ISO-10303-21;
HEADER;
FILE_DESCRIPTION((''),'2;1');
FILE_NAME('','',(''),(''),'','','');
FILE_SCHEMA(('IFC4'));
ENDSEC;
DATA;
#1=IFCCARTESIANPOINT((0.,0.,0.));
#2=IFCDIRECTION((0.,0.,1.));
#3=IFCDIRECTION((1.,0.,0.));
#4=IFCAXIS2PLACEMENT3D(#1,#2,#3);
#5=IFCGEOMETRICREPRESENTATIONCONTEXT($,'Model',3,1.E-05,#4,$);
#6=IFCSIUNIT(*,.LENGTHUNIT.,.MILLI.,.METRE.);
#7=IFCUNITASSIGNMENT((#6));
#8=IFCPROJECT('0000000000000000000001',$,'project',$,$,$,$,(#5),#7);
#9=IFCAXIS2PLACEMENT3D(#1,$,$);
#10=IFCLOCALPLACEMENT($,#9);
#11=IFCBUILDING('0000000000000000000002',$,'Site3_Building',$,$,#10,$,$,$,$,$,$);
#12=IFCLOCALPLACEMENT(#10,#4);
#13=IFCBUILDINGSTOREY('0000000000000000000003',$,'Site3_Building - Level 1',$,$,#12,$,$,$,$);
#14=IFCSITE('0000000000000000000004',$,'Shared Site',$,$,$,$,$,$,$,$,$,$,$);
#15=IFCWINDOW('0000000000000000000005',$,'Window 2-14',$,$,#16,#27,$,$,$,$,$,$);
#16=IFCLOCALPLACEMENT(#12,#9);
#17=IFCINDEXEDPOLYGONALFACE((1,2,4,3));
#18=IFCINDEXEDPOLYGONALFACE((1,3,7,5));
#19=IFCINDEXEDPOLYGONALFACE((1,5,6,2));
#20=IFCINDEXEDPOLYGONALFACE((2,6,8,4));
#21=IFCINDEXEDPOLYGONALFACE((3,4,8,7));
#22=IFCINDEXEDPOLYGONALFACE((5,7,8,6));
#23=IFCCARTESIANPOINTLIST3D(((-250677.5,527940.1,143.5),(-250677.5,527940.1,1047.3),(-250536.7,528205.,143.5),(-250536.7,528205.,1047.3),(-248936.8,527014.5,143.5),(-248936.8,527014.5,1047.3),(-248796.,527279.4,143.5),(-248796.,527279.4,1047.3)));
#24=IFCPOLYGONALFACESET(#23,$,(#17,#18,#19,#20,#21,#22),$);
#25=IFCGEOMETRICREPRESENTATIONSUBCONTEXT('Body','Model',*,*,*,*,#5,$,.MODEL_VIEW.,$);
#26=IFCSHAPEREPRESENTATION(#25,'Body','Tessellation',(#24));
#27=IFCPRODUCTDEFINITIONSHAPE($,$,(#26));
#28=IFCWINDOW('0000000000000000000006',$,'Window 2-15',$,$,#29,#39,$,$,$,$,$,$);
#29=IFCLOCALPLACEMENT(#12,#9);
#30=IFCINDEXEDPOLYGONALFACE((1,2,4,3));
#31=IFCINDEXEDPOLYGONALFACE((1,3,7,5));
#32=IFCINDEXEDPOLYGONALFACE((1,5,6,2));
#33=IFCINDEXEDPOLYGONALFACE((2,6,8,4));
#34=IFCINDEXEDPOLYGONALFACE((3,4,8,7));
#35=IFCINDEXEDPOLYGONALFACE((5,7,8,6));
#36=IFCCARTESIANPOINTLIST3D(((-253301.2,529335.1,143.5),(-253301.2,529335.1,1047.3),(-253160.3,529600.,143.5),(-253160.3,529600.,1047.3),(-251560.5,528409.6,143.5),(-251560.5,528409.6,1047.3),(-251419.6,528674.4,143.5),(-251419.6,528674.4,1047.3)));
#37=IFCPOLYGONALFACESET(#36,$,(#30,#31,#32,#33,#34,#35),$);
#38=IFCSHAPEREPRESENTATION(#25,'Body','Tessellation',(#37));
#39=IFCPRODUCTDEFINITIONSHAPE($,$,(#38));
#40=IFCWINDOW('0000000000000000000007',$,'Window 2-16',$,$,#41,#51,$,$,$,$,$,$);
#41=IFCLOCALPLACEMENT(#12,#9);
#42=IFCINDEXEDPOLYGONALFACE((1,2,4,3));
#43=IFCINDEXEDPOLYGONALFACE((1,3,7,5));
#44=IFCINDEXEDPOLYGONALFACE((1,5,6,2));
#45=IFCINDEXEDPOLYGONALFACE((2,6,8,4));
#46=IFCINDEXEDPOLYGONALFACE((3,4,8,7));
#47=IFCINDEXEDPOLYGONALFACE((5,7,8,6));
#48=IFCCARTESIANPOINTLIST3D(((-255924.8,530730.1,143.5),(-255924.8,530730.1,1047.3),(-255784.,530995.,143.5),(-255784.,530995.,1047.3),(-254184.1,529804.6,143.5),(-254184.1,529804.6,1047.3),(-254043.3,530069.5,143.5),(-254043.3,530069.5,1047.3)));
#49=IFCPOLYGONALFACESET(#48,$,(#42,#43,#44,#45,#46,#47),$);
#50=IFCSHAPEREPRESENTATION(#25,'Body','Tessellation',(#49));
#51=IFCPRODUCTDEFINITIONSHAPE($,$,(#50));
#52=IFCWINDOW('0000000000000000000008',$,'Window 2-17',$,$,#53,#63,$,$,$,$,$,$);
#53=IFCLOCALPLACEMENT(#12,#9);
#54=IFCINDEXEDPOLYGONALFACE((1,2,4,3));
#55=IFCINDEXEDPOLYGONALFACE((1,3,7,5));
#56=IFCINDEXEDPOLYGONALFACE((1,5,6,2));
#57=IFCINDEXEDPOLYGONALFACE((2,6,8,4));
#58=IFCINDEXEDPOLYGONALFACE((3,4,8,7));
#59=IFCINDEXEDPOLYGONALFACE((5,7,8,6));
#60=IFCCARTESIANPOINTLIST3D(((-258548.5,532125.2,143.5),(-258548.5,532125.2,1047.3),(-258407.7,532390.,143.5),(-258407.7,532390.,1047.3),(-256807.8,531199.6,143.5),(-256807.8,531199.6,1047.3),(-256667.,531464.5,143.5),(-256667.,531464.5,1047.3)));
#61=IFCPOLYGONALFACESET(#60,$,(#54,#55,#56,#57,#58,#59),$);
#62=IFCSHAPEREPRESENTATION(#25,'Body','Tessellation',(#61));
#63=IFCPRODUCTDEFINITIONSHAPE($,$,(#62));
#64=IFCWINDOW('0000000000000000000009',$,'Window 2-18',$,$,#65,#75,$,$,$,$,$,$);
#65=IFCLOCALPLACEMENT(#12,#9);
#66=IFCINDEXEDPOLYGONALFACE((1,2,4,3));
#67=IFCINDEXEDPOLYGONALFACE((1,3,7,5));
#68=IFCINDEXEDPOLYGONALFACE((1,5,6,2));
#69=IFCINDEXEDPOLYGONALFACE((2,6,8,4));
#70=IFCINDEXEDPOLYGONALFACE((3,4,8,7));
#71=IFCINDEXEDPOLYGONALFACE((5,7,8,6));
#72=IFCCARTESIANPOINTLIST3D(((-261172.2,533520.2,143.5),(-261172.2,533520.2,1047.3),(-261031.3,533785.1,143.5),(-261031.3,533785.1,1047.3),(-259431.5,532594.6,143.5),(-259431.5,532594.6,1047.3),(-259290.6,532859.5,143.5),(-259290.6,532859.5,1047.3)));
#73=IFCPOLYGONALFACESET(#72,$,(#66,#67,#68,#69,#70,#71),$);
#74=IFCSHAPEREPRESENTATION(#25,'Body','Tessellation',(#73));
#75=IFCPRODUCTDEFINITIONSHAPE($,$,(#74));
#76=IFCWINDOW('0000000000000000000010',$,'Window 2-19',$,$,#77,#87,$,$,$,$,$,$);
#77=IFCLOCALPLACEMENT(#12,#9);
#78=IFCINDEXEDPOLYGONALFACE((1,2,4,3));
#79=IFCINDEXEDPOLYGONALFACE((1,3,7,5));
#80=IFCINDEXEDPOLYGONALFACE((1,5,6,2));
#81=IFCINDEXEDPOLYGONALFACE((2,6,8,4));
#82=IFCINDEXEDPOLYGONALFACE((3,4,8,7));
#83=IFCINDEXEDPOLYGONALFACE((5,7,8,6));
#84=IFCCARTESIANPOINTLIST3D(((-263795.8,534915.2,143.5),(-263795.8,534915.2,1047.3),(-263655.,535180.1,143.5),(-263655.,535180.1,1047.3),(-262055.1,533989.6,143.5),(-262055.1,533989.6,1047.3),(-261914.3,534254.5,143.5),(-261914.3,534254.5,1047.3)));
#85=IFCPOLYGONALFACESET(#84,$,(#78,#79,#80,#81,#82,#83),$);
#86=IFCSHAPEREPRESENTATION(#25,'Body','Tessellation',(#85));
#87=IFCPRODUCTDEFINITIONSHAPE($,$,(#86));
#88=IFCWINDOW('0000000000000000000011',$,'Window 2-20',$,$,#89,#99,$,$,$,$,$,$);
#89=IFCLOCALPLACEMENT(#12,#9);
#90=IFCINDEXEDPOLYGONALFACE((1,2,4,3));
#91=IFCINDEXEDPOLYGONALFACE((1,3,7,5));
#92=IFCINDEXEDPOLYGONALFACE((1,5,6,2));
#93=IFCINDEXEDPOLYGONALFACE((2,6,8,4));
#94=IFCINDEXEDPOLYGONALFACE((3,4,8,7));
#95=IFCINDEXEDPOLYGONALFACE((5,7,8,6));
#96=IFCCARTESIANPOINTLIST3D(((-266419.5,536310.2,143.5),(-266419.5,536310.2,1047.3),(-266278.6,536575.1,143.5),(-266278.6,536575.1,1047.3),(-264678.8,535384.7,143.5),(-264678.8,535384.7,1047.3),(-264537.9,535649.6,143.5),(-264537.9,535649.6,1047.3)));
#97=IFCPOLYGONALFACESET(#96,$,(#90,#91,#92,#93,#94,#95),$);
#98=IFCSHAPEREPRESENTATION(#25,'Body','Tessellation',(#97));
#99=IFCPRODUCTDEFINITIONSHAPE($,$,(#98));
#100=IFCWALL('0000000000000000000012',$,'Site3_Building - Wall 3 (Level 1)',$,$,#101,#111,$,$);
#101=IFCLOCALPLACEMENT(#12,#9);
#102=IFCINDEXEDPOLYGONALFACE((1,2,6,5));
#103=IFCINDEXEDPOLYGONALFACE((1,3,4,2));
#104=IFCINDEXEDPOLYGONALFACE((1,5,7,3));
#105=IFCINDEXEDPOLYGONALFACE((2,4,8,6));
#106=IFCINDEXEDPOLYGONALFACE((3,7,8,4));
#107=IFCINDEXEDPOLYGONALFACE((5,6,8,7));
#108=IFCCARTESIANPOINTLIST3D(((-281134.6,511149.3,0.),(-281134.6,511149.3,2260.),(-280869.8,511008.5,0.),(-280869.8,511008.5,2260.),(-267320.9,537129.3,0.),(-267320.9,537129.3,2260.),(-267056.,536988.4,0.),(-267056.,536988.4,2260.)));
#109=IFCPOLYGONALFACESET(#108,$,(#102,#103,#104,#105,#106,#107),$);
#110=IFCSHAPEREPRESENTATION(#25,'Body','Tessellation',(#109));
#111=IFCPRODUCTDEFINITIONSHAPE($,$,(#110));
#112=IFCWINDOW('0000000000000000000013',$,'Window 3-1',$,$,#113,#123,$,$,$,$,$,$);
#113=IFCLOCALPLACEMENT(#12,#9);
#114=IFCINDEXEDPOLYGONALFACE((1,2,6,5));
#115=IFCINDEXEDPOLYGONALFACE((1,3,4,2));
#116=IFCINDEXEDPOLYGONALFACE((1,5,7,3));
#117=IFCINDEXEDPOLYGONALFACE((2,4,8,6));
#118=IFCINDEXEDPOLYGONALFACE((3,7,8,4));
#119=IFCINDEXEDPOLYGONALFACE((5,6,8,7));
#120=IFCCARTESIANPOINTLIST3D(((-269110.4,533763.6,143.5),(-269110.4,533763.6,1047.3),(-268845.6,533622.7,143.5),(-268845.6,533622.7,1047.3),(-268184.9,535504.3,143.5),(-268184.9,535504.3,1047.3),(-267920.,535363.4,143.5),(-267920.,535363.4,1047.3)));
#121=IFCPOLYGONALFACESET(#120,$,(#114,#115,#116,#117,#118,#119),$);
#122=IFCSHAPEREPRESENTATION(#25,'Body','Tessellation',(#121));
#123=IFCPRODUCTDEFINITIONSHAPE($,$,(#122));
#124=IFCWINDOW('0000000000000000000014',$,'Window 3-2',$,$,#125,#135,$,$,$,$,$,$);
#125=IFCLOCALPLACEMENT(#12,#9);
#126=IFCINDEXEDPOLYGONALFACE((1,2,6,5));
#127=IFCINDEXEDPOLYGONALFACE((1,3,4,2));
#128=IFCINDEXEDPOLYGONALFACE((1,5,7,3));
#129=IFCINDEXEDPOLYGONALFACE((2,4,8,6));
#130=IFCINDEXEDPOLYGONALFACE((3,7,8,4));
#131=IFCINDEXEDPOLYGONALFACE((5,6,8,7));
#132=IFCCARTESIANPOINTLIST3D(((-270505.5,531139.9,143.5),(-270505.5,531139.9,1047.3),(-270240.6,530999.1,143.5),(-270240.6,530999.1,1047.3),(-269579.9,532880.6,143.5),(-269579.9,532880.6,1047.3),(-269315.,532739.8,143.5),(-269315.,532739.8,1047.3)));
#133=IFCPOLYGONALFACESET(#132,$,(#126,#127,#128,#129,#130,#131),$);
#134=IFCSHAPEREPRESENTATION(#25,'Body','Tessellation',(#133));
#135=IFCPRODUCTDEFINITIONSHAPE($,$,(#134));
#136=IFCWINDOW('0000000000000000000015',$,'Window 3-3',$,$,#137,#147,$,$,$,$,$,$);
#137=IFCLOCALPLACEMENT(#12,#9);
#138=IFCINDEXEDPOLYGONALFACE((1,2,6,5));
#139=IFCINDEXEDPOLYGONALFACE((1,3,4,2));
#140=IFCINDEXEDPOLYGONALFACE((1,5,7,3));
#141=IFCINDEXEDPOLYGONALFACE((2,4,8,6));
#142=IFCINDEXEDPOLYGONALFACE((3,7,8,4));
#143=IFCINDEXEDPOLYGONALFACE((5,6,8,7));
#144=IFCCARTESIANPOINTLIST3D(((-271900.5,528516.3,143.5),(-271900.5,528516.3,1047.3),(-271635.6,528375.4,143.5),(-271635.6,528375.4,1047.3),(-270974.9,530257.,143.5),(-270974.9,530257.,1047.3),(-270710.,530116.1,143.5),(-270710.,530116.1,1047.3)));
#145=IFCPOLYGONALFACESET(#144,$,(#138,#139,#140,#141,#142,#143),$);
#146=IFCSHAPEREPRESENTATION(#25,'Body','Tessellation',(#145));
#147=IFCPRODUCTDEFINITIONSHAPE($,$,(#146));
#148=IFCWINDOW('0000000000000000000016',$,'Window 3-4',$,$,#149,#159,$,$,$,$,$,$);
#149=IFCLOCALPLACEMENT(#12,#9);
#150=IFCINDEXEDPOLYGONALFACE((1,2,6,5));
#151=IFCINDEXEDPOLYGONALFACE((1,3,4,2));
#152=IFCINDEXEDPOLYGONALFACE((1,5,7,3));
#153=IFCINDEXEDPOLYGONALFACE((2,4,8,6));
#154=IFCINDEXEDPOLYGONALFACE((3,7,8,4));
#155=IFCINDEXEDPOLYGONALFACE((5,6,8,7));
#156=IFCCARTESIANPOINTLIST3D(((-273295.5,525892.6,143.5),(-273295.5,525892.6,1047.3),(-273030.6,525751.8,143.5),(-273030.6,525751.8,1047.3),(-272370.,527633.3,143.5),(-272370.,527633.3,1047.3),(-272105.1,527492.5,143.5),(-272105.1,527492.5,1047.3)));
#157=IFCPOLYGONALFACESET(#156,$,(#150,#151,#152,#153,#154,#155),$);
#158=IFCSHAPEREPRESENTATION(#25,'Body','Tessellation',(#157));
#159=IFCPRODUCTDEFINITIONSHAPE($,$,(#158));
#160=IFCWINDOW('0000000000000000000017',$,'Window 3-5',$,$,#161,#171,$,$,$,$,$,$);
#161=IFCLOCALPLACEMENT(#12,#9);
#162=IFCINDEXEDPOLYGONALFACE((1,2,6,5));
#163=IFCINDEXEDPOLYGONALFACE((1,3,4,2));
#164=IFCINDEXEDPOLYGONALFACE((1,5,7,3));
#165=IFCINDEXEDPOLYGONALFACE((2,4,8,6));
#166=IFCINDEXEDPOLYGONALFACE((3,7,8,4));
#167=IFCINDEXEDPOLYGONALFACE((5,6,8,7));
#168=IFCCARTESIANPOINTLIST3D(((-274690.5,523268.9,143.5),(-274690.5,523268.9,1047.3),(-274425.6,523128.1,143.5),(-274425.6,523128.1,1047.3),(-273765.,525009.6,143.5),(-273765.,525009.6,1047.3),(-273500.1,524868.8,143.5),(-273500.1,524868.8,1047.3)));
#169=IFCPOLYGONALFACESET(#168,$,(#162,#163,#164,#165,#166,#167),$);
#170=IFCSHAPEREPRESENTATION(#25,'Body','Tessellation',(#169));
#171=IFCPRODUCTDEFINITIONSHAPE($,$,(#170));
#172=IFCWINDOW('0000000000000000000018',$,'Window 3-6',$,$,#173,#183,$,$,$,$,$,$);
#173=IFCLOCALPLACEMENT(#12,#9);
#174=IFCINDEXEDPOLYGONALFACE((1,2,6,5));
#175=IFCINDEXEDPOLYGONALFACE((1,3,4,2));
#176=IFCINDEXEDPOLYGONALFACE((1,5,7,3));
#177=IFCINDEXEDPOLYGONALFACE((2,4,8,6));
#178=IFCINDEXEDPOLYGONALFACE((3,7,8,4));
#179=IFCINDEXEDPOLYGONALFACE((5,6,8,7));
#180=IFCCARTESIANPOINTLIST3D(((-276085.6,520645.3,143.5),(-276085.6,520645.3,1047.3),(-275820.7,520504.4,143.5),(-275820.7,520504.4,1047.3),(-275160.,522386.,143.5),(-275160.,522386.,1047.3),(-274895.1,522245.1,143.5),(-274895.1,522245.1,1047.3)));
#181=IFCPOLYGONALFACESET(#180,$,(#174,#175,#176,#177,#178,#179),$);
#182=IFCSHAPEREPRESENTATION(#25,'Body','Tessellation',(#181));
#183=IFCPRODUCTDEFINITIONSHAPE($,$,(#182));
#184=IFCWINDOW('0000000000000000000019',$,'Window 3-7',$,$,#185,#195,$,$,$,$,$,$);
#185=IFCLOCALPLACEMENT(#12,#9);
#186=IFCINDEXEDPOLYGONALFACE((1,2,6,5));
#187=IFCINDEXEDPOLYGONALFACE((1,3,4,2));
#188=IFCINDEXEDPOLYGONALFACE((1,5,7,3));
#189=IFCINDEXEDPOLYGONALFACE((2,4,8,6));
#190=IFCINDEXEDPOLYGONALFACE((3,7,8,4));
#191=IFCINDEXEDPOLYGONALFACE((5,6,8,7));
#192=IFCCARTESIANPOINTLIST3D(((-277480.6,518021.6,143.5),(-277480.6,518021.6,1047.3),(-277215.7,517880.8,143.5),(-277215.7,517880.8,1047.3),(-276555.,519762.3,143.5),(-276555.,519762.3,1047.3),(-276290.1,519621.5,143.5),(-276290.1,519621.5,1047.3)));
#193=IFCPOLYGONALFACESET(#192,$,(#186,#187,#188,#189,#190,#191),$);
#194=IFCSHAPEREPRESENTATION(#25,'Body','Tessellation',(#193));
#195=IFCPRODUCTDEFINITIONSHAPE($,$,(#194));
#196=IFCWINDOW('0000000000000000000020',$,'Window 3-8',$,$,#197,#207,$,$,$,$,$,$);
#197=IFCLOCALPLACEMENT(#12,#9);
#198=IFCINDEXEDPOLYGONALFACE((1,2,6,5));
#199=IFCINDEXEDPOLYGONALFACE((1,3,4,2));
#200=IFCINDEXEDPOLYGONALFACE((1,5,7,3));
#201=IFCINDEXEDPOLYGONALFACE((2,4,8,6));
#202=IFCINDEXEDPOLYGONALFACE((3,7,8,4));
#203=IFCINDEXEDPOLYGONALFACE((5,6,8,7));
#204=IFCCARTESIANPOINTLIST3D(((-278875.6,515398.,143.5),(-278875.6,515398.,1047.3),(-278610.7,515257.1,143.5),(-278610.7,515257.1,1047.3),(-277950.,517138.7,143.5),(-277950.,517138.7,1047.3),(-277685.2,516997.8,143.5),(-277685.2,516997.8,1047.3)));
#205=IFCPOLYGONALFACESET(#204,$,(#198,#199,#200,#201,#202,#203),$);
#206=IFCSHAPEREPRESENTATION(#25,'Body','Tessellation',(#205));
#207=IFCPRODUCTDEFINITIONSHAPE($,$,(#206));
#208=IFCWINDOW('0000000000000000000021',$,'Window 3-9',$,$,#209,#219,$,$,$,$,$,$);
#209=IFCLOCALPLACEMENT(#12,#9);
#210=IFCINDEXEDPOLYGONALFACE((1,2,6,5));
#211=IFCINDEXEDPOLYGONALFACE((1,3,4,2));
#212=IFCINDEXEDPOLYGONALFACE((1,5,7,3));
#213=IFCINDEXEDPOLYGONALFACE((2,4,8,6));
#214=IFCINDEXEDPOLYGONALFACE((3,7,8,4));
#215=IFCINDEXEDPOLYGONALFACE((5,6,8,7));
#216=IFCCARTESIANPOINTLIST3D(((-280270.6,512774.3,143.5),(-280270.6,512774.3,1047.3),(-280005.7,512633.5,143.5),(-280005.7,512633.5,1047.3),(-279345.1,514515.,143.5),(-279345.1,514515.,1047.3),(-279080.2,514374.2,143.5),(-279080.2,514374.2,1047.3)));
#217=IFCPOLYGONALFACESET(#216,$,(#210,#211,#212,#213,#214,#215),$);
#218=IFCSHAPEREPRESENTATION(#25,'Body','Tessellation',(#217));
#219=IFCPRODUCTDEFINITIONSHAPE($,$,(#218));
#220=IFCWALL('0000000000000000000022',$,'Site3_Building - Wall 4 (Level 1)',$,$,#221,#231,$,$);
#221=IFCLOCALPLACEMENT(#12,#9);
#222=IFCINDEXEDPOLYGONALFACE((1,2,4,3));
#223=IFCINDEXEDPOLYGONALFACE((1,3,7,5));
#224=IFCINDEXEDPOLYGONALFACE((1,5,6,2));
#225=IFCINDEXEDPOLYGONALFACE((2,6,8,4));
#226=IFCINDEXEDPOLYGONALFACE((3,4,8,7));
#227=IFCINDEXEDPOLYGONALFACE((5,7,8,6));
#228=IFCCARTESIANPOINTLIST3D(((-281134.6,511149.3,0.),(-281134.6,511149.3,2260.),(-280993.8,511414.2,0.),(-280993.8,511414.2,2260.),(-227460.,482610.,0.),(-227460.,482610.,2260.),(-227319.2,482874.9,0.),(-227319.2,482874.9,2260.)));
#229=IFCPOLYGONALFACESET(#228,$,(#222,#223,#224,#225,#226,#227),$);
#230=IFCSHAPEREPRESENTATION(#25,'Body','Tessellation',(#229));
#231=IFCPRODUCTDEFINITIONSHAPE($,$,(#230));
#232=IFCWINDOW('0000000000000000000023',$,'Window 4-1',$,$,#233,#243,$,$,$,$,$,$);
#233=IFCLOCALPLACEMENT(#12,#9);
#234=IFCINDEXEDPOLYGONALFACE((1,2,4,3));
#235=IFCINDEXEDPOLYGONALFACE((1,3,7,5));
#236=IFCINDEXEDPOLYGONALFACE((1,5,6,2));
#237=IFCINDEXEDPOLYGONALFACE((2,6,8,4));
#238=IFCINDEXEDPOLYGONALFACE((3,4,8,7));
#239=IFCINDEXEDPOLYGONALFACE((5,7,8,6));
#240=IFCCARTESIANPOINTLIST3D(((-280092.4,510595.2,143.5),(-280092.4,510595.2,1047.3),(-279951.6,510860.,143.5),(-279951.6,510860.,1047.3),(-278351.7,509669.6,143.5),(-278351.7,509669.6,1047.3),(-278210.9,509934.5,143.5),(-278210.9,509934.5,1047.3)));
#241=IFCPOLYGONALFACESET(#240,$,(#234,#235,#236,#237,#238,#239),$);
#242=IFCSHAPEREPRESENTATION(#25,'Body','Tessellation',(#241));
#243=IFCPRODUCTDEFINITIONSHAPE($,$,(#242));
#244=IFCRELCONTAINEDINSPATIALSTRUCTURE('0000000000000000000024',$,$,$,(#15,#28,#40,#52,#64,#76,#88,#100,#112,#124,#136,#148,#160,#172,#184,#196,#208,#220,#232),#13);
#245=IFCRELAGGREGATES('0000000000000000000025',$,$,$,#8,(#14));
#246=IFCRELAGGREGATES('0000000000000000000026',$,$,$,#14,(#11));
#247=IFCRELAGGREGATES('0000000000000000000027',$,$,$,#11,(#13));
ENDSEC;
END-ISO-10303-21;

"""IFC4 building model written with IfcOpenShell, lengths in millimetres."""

from ifc_helpers import new_model, si_unit, frame, origin, origin_with_axes, place, context, subcontext, project, spatial, indexed_curve, outline, extrude, element, save


model = new_model("IFC4")

# Units and contexts
model_context = context("Model", 3, precision=1e-05, world=origin_with_axes())
body_context = subcontext(model_context, "Body", "Model", "MODEL_VIEW")
ifc_project = project(units=[si_unit("LENGTHUNIT", "METRE", prefix="MILLI")], contexts=[model_context])

# Site, building, storey
site = spatial("IfcSite", under=ifc_project, Name="Shared Site")
building_placement = place(None, origin())
building = spatial("IfcBuilding", under=site, at=building_placement, Name="Site3_Building")
storey_placement = place(building_placement, origin_with_axes())
storey = spatial("IfcBuildingStorey", under=building, at=storey_placement, Name="Site3_Building - Level 1")

# Windows
for number, where, z_axis, x_axis, name in (
    (1, (-248796.0, 527279.4, 143.5), (0.0, 0.0, 1.0), (-0.882948, 0.469472, 0.0), "Window 2-14"),
    (2, (-251419.6, 528674.4, 143.5), (0.0, 0.0, 1.0), (-0.882948, 0.469472, 0.0), "Window 2-15"),
    (3, (-254043.3, 530069.5, 143.5), (0.0, 0.0, 1.0), (-0.882948, 0.469472, 0.0), "Window 2-16"),
    (4, (-256667.0, 531464.5, 143.5), (0.0, 0.0, 1.0), (-0.882948, 0.469472, 0.0), "Window 2-17"),
    (5, (-259290.6, 532859.5, 143.5), (0.0, 0.0, 1.0), (-0.882948, 0.469472, 0.0), "Window 2-18"),
    (6, (-261914.3, 534254.5, 143.5), (0.0, 0.0, 1.0), (-0.882948, 0.469472, 0.0), "Window 2-19"),
    (7, (-264537.9, 535649.6, 143.5), (0.0, 0.0, 1.0), (-0.882948, 0.469472, 0.0), "Window 2-20"),
):
    element("IfcWindow", number, at=place(storey_placement, frame(where, z_axis=z_axis, x_axis=x_axis)), inside=storey, Name=name, context=body_context, shape_type="SweptSolid", body=[
        extrude(outline(indexed_curve([(0.0, 0.0), (0.0, 300.0), (1971.5, 300.0), (1971.5, 0.0), (0.0, 0.0)], self_intersect=False)), origin_with_axes(), (0.0, 0.0, 1.0), 903.8),
    ])

# Wall
wall_1_placement = place(storey_placement, frame((-267320.9, 537129.3, 0.0), z_axis=(0.0, 0.0, 1.0), x_axis=(-0.469472, -0.882948, 0.0)))
element("IfcWall", 8, at=wall_1_placement, inside=storey, Name="Site3_Building - Wall 3 (Level 1)", context=body_context, shape_type="SweptSolid", body=[
    extrude(outline(indexed_curve([(0.0, 0.0), (0.0, 300.0), (29424.1, 300.0), (29424.1, 0.0), (0.0, 0.0)], self_intersect=False)), origin_with_axes(), (0.0, 0.0, 1.0), 2260.0),
])

# Windows
for number, where, z_axis, x_axis, name in (
    (9, (-268184.9, 535504.3, 143.5), (0.0, 0.0, 1.0), (-0.469472, -0.882948, 0.0), "Window 3-1"),
    (10, (-269579.9, 532880.6, 143.5), (0.0, 0.0, 1.0), (-0.469472, -0.882948, 0.0), "Window 3-2"),
    (11, (-270974.9, 530257.0, 143.5), (0.0, 0.0, 1.0), (-0.469472, -0.882948, 0.0), "Window 3-3"),
    (12, (-272370.0, 527633.3, 143.5), (0.0, 0.0, 1.0), (-0.469472, -0.882948, 0.0), "Window 3-4"),
    (13, (-273765.0, 525009.6, 143.5), (0.0, 0.0, 1.0), (-0.469472, -0.882948, 0.0), "Window 3-5"),
    (14, (-275160.0, 522386.0, 143.5), (0.0, 0.0, 1.0), (-0.469472, -0.882948, 0.0), "Window 3-6"),
    (15, (-276555.0, 519762.3, 143.5), (0.0, 0.0, 1.0), (-0.469472, -0.882948, 0.0), "Window 3-7"),
    (16, (-277950.0, 517138.7, 143.5), (0.0, 0.0, 1.0), (-0.469472, -0.882948, 0.0), "Window 3-8"),
    (17, (-279345.1, 514515.0, 143.5), (0.0, 0.0, 1.0), (-0.469472, -0.882948, 0.0), "Window 3-9"),
):
    element("IfcWindow", number, at=place(storey_placement, frame(where, z_axis=z_axis, x_axis=x_axis)), inside=storey, Name=name, context=body_context, shape_type="SweptSolid", body=[
        extrude(outline(indexed_curve([(0.0, 0.0), (0.0, 300.0), (1971.5, 300.0), (1971.5, 0.0), (0.0, 0.0)], self_intersect=False)), origin_with_axes(), (0.0, 0.0, 1.0), 903.8),
    ])

# Wall
wall_2_placement = place(storey_placement, frame((-281134.6, 511149.3, 0.0), z_axis=(0.0, 0.0, 1.0), x_axis=(0.882948, -0.469472, 0.0)))
element("IfcWall", 18, at=wall_2_placement, inside=storey, Name="Site3_Building - Wall 4 (Level 1)", context=body_context, shape_type="SweptSolid", body=[
    extrude(outline(indexed_curve([(0.0, 0.0), (0.0, 300.0), (60790.3, 300.0), (60790.3, 0.0), (0.0, 0.0)], self_intersect=False)), origin_with_axes(), (0.0, 0.0, 1.0), 2260.0),
])

# Window
for number, where, z_axis, x_axis, name in (
    (19, (-280092.4, 510595.2, 143.5), (0.0, 0.0, 1.0), (0.882948, -0.469472, 0.0), "Window 4-1"),
):
    element("IfcWindow", number, at=place(storey_placement, frame(where, z_axis=z_axis, x_axis=x_axis)), inside=storey, Name=name, context=body_context, shape_type="SweptSolid", body=[
        extrude(outline(indexed_curve([(0.0, 0.0), (0.0, 300.0), (1971.5, 300.0), (1971.5, 0.0), (0.0, 0.0)], self_intersect=False)), origin_with_axes(), (0.0, 0.0, 1.0), 903.8),
    ])

save(model, "model.ifc")
